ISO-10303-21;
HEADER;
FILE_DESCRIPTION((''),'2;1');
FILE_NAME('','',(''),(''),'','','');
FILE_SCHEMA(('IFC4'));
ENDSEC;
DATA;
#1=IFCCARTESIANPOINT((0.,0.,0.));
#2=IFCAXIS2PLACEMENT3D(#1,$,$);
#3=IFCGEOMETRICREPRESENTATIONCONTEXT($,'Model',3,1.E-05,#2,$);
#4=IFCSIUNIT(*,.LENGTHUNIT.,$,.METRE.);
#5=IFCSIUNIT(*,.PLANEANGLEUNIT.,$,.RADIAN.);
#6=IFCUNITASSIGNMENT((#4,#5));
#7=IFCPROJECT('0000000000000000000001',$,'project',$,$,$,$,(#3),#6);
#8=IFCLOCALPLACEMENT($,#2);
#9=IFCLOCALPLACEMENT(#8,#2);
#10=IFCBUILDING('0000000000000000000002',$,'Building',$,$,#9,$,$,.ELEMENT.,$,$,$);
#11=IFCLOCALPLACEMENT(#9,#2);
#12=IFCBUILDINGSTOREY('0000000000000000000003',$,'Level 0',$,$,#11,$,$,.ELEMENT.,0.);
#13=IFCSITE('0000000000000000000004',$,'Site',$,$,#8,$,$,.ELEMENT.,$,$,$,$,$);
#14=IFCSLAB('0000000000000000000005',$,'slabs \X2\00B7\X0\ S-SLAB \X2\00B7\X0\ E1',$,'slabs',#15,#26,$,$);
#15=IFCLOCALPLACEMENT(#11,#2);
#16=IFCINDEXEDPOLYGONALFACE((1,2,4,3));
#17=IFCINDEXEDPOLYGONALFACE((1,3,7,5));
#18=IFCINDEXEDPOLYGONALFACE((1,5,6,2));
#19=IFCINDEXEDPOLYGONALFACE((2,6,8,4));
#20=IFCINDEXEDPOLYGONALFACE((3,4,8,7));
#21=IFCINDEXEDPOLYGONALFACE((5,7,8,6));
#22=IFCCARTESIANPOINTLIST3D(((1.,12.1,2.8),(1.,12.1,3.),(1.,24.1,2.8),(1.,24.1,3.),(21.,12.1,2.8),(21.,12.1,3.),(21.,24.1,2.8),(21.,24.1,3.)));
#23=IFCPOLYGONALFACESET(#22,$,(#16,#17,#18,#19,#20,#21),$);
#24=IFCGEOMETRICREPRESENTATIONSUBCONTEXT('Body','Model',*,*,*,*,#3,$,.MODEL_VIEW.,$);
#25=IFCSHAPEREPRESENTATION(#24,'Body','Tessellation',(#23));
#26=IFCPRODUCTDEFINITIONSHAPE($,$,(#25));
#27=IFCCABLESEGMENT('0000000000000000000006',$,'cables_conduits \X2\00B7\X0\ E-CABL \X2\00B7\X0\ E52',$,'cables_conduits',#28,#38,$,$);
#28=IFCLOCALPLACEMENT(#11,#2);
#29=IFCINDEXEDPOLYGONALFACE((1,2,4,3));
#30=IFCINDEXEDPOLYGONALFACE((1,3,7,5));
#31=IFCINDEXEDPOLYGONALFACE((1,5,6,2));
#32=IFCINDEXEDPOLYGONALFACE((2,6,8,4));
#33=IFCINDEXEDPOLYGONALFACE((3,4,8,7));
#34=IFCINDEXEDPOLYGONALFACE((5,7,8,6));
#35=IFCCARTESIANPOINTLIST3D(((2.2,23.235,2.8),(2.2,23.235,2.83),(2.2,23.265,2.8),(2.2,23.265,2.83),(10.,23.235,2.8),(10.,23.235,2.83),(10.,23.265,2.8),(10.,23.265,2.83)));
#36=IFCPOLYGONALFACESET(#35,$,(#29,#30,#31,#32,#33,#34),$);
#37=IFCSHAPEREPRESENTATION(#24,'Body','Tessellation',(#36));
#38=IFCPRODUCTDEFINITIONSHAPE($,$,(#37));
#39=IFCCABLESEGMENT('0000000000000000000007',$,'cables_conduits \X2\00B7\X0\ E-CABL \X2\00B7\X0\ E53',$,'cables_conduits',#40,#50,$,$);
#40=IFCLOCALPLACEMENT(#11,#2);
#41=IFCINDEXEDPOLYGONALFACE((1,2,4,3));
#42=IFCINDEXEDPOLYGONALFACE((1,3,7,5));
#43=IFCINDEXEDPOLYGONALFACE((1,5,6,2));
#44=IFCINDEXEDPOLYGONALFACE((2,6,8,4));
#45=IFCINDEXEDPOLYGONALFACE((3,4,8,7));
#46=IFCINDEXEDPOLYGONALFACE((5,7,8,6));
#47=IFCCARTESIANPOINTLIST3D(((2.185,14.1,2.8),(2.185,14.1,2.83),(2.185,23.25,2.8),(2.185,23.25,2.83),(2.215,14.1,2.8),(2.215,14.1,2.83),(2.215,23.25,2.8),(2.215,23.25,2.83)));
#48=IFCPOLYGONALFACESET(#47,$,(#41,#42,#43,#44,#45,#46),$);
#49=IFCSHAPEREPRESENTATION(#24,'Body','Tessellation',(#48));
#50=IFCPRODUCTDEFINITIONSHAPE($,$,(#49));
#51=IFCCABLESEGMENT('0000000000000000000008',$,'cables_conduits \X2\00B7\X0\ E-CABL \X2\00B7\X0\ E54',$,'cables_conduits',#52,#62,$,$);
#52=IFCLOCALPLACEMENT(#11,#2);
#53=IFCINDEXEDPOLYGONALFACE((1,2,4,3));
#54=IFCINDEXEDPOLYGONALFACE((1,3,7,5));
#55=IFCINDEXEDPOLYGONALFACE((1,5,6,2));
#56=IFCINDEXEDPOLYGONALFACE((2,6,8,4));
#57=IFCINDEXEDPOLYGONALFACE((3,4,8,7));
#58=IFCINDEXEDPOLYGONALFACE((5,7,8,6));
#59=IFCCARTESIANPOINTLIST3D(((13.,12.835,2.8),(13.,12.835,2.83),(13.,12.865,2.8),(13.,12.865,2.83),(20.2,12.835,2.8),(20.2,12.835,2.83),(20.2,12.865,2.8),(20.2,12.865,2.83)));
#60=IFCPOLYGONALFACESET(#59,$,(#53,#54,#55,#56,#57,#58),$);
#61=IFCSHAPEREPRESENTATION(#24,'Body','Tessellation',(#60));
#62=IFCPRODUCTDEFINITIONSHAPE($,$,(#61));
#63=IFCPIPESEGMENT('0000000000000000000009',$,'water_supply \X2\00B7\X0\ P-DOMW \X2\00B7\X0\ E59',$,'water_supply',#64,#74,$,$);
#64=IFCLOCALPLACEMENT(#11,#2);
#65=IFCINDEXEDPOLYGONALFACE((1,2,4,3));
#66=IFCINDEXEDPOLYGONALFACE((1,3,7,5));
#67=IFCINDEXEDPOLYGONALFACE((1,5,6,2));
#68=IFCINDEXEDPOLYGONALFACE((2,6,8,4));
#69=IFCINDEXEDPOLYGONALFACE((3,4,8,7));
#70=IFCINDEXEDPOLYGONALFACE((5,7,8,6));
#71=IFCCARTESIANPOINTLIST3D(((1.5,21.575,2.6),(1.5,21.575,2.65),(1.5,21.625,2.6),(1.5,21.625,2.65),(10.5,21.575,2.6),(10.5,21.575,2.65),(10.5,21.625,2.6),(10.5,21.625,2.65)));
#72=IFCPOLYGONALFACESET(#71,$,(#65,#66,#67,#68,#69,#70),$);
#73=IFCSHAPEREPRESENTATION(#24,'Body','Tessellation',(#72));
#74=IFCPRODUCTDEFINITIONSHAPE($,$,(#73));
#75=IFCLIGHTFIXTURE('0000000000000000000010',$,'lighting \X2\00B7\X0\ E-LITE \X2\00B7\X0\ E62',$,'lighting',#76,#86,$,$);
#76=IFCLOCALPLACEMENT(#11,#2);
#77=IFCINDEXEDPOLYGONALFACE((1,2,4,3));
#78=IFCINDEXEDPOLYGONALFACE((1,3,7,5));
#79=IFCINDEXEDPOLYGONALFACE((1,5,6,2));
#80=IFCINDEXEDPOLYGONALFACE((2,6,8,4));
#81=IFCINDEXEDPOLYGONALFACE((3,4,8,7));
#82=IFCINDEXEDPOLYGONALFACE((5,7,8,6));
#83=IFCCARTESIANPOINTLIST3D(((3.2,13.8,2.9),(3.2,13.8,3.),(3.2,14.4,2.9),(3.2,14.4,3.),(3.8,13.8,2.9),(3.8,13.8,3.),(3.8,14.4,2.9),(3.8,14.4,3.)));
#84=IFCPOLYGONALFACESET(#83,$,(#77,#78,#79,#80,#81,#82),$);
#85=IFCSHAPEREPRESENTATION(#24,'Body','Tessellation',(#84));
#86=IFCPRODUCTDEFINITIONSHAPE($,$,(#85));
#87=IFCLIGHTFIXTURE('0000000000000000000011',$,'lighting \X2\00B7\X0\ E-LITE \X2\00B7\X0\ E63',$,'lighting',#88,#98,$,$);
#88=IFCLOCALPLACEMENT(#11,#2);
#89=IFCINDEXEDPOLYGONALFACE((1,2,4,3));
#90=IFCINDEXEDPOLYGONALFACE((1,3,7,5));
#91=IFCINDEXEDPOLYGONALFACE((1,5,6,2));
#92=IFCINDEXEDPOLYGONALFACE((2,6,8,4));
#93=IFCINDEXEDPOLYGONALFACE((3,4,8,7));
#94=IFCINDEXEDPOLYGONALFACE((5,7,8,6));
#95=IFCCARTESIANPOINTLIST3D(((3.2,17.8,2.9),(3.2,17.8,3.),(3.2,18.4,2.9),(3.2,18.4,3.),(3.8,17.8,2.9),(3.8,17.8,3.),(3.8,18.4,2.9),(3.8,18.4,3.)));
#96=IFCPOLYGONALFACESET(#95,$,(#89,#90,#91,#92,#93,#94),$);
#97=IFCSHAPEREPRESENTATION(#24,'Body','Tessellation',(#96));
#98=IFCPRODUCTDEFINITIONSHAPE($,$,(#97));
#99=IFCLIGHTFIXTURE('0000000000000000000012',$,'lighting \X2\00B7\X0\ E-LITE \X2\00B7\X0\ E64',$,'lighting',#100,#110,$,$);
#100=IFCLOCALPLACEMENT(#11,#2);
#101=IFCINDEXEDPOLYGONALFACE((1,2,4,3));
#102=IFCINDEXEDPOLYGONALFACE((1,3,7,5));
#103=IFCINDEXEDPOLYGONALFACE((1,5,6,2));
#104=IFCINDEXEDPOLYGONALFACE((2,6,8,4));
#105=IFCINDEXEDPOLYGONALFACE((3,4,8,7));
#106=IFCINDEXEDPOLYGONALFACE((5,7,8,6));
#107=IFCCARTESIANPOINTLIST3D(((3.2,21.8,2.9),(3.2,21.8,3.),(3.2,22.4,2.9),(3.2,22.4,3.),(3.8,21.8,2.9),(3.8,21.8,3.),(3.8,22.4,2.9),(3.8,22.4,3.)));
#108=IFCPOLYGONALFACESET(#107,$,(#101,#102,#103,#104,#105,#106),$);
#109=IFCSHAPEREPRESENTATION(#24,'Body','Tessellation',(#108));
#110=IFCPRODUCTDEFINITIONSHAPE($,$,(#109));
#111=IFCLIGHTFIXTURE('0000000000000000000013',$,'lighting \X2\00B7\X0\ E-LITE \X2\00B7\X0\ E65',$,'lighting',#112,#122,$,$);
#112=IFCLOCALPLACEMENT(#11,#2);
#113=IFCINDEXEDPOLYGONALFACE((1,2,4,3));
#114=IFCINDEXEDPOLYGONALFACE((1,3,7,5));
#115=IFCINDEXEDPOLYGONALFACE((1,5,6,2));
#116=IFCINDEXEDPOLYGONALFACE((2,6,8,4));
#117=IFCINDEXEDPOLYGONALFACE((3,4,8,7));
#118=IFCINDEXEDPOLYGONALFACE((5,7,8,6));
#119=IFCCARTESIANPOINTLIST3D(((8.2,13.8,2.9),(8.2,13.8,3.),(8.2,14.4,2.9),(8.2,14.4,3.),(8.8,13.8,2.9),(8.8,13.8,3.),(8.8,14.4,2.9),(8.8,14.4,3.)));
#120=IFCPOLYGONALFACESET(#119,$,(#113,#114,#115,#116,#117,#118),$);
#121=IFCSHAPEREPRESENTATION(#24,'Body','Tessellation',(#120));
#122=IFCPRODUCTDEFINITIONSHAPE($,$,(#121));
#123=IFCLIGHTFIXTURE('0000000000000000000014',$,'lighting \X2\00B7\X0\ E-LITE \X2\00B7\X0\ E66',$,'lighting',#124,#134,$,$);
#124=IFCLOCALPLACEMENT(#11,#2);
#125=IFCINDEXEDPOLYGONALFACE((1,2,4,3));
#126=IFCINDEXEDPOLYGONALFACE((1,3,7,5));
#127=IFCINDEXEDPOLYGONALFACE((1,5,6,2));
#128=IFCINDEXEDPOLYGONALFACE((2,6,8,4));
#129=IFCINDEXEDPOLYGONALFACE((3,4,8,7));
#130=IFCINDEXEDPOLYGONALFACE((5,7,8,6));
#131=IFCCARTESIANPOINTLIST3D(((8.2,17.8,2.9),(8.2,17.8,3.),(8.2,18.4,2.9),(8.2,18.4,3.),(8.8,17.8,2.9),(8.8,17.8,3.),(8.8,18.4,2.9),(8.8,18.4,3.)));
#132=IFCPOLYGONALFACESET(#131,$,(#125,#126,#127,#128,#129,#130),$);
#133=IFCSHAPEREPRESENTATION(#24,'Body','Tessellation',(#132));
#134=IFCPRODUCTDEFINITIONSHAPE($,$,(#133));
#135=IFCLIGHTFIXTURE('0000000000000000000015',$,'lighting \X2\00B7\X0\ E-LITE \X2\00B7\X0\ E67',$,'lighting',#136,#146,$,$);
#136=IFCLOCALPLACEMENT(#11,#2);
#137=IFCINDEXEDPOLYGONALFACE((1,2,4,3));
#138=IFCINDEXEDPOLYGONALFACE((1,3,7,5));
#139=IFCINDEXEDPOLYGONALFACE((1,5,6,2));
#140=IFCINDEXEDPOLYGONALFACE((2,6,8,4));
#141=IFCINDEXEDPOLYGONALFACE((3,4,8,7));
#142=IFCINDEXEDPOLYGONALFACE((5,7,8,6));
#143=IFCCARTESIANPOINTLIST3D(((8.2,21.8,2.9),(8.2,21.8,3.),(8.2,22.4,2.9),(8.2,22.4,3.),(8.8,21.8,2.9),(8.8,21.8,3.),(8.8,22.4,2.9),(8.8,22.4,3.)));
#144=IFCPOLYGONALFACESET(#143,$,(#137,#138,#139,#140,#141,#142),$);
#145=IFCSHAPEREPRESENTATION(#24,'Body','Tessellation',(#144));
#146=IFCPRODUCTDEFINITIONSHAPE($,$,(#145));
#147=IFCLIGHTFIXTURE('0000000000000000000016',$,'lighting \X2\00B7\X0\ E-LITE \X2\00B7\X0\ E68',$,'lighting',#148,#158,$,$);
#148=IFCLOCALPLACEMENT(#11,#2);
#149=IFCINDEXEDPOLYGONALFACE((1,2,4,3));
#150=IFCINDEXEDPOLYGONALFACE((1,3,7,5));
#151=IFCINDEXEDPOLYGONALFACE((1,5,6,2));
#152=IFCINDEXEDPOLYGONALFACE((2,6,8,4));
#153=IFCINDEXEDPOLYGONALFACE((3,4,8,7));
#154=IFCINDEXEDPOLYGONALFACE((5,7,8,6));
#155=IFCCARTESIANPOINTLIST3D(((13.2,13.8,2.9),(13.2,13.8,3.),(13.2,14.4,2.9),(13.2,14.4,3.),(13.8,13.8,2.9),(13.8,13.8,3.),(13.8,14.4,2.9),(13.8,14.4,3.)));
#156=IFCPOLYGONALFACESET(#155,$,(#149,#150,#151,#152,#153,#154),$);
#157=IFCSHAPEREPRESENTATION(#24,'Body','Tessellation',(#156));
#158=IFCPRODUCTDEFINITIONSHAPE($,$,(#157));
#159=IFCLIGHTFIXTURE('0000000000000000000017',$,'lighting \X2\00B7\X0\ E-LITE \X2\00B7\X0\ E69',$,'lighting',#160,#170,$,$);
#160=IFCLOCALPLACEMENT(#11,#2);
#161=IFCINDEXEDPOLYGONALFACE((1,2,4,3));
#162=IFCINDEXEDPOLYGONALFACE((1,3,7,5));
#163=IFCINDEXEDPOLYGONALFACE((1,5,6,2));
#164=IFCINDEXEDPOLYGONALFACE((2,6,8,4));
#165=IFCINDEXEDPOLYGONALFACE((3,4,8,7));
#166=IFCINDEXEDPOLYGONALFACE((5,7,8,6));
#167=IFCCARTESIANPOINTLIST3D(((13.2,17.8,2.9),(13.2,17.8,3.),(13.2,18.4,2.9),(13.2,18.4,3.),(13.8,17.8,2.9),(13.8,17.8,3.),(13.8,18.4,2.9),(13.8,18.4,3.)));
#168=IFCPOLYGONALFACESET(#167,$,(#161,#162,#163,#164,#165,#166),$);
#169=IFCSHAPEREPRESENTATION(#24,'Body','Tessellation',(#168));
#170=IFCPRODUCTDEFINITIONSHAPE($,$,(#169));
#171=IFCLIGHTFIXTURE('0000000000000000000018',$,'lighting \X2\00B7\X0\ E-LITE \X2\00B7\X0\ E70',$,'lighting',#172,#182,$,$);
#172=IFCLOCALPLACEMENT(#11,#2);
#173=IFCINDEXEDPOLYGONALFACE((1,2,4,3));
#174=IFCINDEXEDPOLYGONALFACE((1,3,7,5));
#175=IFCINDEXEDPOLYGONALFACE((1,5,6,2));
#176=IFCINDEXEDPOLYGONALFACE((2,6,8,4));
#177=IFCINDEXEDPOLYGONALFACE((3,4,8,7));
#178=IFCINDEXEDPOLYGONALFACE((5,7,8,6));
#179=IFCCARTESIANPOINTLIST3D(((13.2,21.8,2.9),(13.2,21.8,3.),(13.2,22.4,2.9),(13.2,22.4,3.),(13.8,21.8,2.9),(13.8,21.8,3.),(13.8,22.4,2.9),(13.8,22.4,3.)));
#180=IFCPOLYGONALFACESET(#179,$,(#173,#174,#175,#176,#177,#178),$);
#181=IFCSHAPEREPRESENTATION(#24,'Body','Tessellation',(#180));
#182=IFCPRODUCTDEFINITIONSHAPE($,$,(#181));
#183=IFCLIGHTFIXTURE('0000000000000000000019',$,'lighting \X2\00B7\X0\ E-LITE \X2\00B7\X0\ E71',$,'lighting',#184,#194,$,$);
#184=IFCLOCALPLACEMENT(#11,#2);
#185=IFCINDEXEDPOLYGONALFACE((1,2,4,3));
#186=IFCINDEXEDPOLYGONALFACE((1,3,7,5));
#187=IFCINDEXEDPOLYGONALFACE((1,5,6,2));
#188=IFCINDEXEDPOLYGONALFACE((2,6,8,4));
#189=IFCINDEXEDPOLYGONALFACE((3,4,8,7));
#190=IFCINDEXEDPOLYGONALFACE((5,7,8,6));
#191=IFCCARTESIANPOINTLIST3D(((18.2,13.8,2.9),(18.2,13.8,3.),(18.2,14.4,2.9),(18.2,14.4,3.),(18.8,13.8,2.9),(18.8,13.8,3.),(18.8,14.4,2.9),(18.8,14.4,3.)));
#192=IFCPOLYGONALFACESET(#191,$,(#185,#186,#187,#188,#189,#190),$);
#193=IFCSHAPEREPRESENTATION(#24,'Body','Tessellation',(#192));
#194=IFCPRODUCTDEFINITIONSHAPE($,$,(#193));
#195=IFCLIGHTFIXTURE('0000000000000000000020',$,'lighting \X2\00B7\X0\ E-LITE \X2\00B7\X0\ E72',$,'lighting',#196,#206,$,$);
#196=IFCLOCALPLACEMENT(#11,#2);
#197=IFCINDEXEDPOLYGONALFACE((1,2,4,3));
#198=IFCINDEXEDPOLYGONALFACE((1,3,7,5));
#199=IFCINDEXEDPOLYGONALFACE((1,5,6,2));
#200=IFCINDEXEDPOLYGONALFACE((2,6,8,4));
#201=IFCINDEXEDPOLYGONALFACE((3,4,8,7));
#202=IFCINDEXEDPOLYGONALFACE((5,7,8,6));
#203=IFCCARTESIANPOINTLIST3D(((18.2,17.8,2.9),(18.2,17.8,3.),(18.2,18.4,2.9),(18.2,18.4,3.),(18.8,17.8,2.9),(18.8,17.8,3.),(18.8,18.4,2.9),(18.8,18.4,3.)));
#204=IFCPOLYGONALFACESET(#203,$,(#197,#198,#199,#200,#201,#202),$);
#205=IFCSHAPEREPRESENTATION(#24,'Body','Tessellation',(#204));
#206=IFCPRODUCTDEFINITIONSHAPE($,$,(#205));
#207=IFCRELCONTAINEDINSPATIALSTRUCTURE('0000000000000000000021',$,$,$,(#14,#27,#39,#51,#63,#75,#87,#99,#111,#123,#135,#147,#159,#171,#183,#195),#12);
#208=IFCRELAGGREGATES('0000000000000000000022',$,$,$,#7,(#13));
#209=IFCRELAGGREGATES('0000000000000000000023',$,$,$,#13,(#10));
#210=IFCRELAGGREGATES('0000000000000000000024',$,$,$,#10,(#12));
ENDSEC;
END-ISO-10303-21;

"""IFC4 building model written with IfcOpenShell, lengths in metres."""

from ifc_helpers import new_model, si_unit, frame, origin, place, context, subcontext, project, spatial, polyline, outline, extrude, element, save


model = new_model("IFC4")

# Units and contexts
model_context = context("Model", 3, precision=1e-05, world=origin())
body_context = subcontext(model_context, "Body", "Model", "MODEL_VIEW")
ifc_project = project(units=[si_unit("LENGTHUNIT", "METRE"), si_unit("PLANEANGLEUNIT", "RADIAN")], contexts=[model_context])

# Site, building, storey
site_placement = place(None, origin())
site = spatial("IfcSite", under=ifc_project, at=site_placement, Name="Site", CompositionType="ELEMENT")
building_placement = place(site_placement, origin())
building = spatial("IfcBuilding", under=site, at=building_placement, Name="Building", CompositionType="ELEMENT")
storey_placement = place(building_placement, origin())
storey = spatial("IfcBuildingStorey", under=building, at=storey_placement, Name="Level 0", CompositionType="ELEMENT", Elevation=0.0)

# Slab
slab_placement = place(storey_placement, frame((0.0, 0.0, 2.8)))
element("IfcSlab", 1, at=slab_placement, inside=storey, Name="slabs · S-SLAB · E1", ObjectType="slabs", context=body_context, shape_type="SweptSolid", body=[
    extrude(outline(polyline([(1.0, 12.1), (21.0, 12.1), (21.0, 24.1), (1.0, 24.1), (1.0, 12.1)])), origin(), (0.0, 0.0, 1.0), 0.2),
])

# Cable segments
cable_segment_1_placement = place(storey_placement, frame((0.0, 0.0, 2.8)))
element("IfcCableSegment", 2, at=cable_segment_1_placement, inside=storey, Name="cables_conduits · E-CABL · E52", ObjectType="cables_conduits", context=body_context, shape_type="SweptSolid", body=[
    extrude(outline(polyline([(2.2, 23.235), (10.0, 23.235), (10.0, 23.265), (2.2, 23.265), (2.2, 23.235)])), origin(), (0.0, 0.0, 1.0), 0.03),
])
cable_segment_2_placement = place(storey_placement, frame((0.0, 0.0, 2.8)))
element("IfcCableSegment", 3, at=cable_segment_2_placement, inside=storey, Name="cables_conduits · E-CABL · E53", ObjectType="cables_conduits", context=body_context, shape_type="SweptSolid", body=[
    extrude(outline(polyline([(2.185, 23.25), (2.185, 14.1), (2.215, 14.1), (2.215, 23.25), (2.185, 23.25)])), origin(), (0.0, 0.0, 1.0), 0.03),
])
cable_segment_3_placement = place(storey_placement, frame((0.0, 0.0, 2.8)))
element("IfcCableSegment", 4, at=cable_segment_3_placement, inside=storey, Name="cables_conduits · E-CABL · E54", ObjectType="cables_conduits", context=body_context, shape_type="SweptSolid", body=[
    extrude(outline(polyline([(20.2, 12.865), (13.0, 12.865), (13.0, 12.835), (20.2, 12.835), (20.2, 12.865)])), origin(), (0.0, 0.0, 1.0), 0.03),
])

# Pipe segment
pipe_segment_placement = place(storey_placement, frame((0.0, 0.0, 2.6)))
element("IfcPipeSegment", 5, at=pipe_segment_placement, inside=storey, Name="water_supply · P-DOMW · E59", ObjectType="water_supply", context=body_context, shape_type="SweptSolid", body=[
    extrude(outline(polyline([(1.5, 21.575), (10.5, 21.575), (10.5, 21.625), (1.5, 21.625), (1.5, 21.575)])), origin(), (0.0, 0.0, 1.0), 0.05),
])

# Light fixtures
light_fixture_1_placement = place(storey_placement, frame((0.0, 0.0, 2.9)))
element("IfcLightFixture", 6, at=light_fixture_1_placement, inside=storey, Name="lighting · E-LITE · E62", ObjectType="lighting", context=body_context, shape_type="SweptSolid", body=[
    extrude(outline(polyline([(3.2, 13.8), (3.8, 13.8), (3.8, 14.4), (3.2, 14.4), (3.2, 13.8)])), origin(), (0.0, 0.0, 1.0), 0.1),
])
light_fixture_2_placement = place(storey_placement, frame((0.0, 0.0, 2.9)))
element("IfcLightFixture", 7, at=light_fixture_2_placement, inside=storey, Name="lighting · E-LITE · E63", ObjectType="lighting", context=body_context, shape_type="SweptSolid", body=[
    extrude(outline(polyline([(3.2, 17.8), (3.8, 17.8), (3.8, 18.4), (3.2, 18.4), (3.2, 17.8)])), origin(), (0.0, 0.0, 1.0), 0.1),
])
light_fixture_3_placement = place(storey_placement, frame((0.0, 0.0, 2.9)))
element("IfcLightFixture", 8, at=light_fixture_3_placement, inside=storey, Name="lighting · E-LITE · E64", ObjectType="lighting", context=body_context, shape_type="SweptSolid", body=[
    extrude(outline(polyline([(3.2, 21.8), (3.8, 21.8), (3.8, 22.4), (3.2, 22.4), (3.2, 21.8)])), origin(), (0.0, 0.0, 1.0), 0.1),
])
light_fixture_4_placement = place(storey_placement, frame((0.0, 0.0, 2.9)))
element("IfcLightFixture", 9, at=light_fixture_4_placement, inside=storey, Name="lighting · E-LITE · E65", ObjectType="lighting", context=body_context, shape_type="SweptSolid", body=[
    extrude(outline(polyline([(8.2, 13.8), (8.8, 13.8), (8.8, 14.4), (8.2, 14.4), (8.2, 13.8)])), origin(), (0.0, 0.0, 1.0), 0.1),
])
light_fixture_5_placement = place(storey_placement, frame((0.0, 0.0, 2.9)))
element("IfcLightFixture", 10, at=light_fixture_5_placement, inside=storey, Name="lighting · E-LITE · E66", ObjectType="lighting", context=body_context, shape_type="SweptSolid", body=[
    extrude(outline(polyline([(8.2, 17.8), (8.8, 17.8), (8.8, 18.4), (8.2, 18.4), (8.2, 17.8)])), origin(), (0.0, 0.0, 1.0), 0.1),
])
light_fixture_6_placement = place(storey_placement, frame((0.0, 0.0, 2.9)))
element("IfcLightFixture", 11, at=light_fixture_6_placement, inside=storey, Name="lighting · E-LITE · E67", ObjectType="lighting", context=body_context, shape_type="SweptSolid", body=[
    extrude(outline(polyline([(8.2, 21.8), (8.8, 21.8), (8.8, 22.4), (8.2, 22.4), (8.2, 21.8)])), origin(), (0.0, 0.0, 1.0), 0.1),
])
light_fixture_7_placement = place(storey_placement, frame((0.0, 0.0, 2.9)))
element("IfcLightFixture", 12, at=light_fixture_7_placement, inside=storey, Name="lighting · E-LITE · E68", ObjectType="lighting", context=body_context, shape_type="SweptSolid", body=[
    extrude(outline(polyline([(13.2, 13.8), (13.8, 13.8), (13.8, 14.4), (13.2, 14.4), (13.2, 13.8)])), origin(), (0.0, 0.0, 1.0), 0.1),
])
light_fixture_8_placement = place(storey_placement, frame((0.0, 0.0, 2.9)))
element("IfcLightFixture", 13, at=light_fixture_8_placement, inside=storey, Name="lighting · E-LITE · E69", ObjectType="lighting", context=body_context, shape_type="SweptSolid", body=[
    extrude(outline(polyline([(13.2, 17.8), (13.8, 17.8), (13.8, 18.4), (13.2, 18.4), (13.2, 17.8)])), origin(), (0.0, 0.0, 1.0), 0.1),
])
light_fixture_9_placement = place(storey_placement, frame((0.0, 0.0, 2.9)))
element("IfcLightFixture", 14, at=light_fixture_9_placement, inside=storey, Name="lighting · E-LITE · E70", ObjectType="lighting", context=body_context, shape_type="SweptSolid", body=[
    extrude(outline(polyline([(13.2, 21.8), (13.8, 21.8), (13.8, 22.4), (13.2, 22.4), (13.2, 21.8)])), origin(), (0.0, 0.0, 1.0), 0.1),
])
light_fixture_10_placement = place(storey_placement, frame((0.0, 0.0, 2.9)))
element("IfcLightFixture", 15, at=light_fixture_10_placement, inside=storey, Name="lighting · E-LITE · E71", ObjectType="lighting", context=body_context, shape_type="SweptSolid", body=[
    extrude(outline(polyline([(18.2, 13.8), (18.8, 13.8), (18.8, 14.4), (18.2, 14.4), (18.2, 13.8)])), origin(), (0.0, 0.0, 1.0), 0.1),
])
light_fixture_11_placement = place(storey_placement, frame((0.0, 0.0, 2.9)))
element("IfcLightFixture", 16, at=light_fixture_11_placement, inside=storey, Name="lighting · E-LITE · E72", ObjectType="lighting", context=body_context, shape_type="SweptSolid", body=[
    extrude(outline(polyline([(18.2, 17.8), (18.8, 17.8), (18.8, 18.4), (18.2, 18.4), (18.2, 17.8)])), origin(), (0.0, 0.0, 1.0), 0.1),
])

save(model, "model.ifc")
